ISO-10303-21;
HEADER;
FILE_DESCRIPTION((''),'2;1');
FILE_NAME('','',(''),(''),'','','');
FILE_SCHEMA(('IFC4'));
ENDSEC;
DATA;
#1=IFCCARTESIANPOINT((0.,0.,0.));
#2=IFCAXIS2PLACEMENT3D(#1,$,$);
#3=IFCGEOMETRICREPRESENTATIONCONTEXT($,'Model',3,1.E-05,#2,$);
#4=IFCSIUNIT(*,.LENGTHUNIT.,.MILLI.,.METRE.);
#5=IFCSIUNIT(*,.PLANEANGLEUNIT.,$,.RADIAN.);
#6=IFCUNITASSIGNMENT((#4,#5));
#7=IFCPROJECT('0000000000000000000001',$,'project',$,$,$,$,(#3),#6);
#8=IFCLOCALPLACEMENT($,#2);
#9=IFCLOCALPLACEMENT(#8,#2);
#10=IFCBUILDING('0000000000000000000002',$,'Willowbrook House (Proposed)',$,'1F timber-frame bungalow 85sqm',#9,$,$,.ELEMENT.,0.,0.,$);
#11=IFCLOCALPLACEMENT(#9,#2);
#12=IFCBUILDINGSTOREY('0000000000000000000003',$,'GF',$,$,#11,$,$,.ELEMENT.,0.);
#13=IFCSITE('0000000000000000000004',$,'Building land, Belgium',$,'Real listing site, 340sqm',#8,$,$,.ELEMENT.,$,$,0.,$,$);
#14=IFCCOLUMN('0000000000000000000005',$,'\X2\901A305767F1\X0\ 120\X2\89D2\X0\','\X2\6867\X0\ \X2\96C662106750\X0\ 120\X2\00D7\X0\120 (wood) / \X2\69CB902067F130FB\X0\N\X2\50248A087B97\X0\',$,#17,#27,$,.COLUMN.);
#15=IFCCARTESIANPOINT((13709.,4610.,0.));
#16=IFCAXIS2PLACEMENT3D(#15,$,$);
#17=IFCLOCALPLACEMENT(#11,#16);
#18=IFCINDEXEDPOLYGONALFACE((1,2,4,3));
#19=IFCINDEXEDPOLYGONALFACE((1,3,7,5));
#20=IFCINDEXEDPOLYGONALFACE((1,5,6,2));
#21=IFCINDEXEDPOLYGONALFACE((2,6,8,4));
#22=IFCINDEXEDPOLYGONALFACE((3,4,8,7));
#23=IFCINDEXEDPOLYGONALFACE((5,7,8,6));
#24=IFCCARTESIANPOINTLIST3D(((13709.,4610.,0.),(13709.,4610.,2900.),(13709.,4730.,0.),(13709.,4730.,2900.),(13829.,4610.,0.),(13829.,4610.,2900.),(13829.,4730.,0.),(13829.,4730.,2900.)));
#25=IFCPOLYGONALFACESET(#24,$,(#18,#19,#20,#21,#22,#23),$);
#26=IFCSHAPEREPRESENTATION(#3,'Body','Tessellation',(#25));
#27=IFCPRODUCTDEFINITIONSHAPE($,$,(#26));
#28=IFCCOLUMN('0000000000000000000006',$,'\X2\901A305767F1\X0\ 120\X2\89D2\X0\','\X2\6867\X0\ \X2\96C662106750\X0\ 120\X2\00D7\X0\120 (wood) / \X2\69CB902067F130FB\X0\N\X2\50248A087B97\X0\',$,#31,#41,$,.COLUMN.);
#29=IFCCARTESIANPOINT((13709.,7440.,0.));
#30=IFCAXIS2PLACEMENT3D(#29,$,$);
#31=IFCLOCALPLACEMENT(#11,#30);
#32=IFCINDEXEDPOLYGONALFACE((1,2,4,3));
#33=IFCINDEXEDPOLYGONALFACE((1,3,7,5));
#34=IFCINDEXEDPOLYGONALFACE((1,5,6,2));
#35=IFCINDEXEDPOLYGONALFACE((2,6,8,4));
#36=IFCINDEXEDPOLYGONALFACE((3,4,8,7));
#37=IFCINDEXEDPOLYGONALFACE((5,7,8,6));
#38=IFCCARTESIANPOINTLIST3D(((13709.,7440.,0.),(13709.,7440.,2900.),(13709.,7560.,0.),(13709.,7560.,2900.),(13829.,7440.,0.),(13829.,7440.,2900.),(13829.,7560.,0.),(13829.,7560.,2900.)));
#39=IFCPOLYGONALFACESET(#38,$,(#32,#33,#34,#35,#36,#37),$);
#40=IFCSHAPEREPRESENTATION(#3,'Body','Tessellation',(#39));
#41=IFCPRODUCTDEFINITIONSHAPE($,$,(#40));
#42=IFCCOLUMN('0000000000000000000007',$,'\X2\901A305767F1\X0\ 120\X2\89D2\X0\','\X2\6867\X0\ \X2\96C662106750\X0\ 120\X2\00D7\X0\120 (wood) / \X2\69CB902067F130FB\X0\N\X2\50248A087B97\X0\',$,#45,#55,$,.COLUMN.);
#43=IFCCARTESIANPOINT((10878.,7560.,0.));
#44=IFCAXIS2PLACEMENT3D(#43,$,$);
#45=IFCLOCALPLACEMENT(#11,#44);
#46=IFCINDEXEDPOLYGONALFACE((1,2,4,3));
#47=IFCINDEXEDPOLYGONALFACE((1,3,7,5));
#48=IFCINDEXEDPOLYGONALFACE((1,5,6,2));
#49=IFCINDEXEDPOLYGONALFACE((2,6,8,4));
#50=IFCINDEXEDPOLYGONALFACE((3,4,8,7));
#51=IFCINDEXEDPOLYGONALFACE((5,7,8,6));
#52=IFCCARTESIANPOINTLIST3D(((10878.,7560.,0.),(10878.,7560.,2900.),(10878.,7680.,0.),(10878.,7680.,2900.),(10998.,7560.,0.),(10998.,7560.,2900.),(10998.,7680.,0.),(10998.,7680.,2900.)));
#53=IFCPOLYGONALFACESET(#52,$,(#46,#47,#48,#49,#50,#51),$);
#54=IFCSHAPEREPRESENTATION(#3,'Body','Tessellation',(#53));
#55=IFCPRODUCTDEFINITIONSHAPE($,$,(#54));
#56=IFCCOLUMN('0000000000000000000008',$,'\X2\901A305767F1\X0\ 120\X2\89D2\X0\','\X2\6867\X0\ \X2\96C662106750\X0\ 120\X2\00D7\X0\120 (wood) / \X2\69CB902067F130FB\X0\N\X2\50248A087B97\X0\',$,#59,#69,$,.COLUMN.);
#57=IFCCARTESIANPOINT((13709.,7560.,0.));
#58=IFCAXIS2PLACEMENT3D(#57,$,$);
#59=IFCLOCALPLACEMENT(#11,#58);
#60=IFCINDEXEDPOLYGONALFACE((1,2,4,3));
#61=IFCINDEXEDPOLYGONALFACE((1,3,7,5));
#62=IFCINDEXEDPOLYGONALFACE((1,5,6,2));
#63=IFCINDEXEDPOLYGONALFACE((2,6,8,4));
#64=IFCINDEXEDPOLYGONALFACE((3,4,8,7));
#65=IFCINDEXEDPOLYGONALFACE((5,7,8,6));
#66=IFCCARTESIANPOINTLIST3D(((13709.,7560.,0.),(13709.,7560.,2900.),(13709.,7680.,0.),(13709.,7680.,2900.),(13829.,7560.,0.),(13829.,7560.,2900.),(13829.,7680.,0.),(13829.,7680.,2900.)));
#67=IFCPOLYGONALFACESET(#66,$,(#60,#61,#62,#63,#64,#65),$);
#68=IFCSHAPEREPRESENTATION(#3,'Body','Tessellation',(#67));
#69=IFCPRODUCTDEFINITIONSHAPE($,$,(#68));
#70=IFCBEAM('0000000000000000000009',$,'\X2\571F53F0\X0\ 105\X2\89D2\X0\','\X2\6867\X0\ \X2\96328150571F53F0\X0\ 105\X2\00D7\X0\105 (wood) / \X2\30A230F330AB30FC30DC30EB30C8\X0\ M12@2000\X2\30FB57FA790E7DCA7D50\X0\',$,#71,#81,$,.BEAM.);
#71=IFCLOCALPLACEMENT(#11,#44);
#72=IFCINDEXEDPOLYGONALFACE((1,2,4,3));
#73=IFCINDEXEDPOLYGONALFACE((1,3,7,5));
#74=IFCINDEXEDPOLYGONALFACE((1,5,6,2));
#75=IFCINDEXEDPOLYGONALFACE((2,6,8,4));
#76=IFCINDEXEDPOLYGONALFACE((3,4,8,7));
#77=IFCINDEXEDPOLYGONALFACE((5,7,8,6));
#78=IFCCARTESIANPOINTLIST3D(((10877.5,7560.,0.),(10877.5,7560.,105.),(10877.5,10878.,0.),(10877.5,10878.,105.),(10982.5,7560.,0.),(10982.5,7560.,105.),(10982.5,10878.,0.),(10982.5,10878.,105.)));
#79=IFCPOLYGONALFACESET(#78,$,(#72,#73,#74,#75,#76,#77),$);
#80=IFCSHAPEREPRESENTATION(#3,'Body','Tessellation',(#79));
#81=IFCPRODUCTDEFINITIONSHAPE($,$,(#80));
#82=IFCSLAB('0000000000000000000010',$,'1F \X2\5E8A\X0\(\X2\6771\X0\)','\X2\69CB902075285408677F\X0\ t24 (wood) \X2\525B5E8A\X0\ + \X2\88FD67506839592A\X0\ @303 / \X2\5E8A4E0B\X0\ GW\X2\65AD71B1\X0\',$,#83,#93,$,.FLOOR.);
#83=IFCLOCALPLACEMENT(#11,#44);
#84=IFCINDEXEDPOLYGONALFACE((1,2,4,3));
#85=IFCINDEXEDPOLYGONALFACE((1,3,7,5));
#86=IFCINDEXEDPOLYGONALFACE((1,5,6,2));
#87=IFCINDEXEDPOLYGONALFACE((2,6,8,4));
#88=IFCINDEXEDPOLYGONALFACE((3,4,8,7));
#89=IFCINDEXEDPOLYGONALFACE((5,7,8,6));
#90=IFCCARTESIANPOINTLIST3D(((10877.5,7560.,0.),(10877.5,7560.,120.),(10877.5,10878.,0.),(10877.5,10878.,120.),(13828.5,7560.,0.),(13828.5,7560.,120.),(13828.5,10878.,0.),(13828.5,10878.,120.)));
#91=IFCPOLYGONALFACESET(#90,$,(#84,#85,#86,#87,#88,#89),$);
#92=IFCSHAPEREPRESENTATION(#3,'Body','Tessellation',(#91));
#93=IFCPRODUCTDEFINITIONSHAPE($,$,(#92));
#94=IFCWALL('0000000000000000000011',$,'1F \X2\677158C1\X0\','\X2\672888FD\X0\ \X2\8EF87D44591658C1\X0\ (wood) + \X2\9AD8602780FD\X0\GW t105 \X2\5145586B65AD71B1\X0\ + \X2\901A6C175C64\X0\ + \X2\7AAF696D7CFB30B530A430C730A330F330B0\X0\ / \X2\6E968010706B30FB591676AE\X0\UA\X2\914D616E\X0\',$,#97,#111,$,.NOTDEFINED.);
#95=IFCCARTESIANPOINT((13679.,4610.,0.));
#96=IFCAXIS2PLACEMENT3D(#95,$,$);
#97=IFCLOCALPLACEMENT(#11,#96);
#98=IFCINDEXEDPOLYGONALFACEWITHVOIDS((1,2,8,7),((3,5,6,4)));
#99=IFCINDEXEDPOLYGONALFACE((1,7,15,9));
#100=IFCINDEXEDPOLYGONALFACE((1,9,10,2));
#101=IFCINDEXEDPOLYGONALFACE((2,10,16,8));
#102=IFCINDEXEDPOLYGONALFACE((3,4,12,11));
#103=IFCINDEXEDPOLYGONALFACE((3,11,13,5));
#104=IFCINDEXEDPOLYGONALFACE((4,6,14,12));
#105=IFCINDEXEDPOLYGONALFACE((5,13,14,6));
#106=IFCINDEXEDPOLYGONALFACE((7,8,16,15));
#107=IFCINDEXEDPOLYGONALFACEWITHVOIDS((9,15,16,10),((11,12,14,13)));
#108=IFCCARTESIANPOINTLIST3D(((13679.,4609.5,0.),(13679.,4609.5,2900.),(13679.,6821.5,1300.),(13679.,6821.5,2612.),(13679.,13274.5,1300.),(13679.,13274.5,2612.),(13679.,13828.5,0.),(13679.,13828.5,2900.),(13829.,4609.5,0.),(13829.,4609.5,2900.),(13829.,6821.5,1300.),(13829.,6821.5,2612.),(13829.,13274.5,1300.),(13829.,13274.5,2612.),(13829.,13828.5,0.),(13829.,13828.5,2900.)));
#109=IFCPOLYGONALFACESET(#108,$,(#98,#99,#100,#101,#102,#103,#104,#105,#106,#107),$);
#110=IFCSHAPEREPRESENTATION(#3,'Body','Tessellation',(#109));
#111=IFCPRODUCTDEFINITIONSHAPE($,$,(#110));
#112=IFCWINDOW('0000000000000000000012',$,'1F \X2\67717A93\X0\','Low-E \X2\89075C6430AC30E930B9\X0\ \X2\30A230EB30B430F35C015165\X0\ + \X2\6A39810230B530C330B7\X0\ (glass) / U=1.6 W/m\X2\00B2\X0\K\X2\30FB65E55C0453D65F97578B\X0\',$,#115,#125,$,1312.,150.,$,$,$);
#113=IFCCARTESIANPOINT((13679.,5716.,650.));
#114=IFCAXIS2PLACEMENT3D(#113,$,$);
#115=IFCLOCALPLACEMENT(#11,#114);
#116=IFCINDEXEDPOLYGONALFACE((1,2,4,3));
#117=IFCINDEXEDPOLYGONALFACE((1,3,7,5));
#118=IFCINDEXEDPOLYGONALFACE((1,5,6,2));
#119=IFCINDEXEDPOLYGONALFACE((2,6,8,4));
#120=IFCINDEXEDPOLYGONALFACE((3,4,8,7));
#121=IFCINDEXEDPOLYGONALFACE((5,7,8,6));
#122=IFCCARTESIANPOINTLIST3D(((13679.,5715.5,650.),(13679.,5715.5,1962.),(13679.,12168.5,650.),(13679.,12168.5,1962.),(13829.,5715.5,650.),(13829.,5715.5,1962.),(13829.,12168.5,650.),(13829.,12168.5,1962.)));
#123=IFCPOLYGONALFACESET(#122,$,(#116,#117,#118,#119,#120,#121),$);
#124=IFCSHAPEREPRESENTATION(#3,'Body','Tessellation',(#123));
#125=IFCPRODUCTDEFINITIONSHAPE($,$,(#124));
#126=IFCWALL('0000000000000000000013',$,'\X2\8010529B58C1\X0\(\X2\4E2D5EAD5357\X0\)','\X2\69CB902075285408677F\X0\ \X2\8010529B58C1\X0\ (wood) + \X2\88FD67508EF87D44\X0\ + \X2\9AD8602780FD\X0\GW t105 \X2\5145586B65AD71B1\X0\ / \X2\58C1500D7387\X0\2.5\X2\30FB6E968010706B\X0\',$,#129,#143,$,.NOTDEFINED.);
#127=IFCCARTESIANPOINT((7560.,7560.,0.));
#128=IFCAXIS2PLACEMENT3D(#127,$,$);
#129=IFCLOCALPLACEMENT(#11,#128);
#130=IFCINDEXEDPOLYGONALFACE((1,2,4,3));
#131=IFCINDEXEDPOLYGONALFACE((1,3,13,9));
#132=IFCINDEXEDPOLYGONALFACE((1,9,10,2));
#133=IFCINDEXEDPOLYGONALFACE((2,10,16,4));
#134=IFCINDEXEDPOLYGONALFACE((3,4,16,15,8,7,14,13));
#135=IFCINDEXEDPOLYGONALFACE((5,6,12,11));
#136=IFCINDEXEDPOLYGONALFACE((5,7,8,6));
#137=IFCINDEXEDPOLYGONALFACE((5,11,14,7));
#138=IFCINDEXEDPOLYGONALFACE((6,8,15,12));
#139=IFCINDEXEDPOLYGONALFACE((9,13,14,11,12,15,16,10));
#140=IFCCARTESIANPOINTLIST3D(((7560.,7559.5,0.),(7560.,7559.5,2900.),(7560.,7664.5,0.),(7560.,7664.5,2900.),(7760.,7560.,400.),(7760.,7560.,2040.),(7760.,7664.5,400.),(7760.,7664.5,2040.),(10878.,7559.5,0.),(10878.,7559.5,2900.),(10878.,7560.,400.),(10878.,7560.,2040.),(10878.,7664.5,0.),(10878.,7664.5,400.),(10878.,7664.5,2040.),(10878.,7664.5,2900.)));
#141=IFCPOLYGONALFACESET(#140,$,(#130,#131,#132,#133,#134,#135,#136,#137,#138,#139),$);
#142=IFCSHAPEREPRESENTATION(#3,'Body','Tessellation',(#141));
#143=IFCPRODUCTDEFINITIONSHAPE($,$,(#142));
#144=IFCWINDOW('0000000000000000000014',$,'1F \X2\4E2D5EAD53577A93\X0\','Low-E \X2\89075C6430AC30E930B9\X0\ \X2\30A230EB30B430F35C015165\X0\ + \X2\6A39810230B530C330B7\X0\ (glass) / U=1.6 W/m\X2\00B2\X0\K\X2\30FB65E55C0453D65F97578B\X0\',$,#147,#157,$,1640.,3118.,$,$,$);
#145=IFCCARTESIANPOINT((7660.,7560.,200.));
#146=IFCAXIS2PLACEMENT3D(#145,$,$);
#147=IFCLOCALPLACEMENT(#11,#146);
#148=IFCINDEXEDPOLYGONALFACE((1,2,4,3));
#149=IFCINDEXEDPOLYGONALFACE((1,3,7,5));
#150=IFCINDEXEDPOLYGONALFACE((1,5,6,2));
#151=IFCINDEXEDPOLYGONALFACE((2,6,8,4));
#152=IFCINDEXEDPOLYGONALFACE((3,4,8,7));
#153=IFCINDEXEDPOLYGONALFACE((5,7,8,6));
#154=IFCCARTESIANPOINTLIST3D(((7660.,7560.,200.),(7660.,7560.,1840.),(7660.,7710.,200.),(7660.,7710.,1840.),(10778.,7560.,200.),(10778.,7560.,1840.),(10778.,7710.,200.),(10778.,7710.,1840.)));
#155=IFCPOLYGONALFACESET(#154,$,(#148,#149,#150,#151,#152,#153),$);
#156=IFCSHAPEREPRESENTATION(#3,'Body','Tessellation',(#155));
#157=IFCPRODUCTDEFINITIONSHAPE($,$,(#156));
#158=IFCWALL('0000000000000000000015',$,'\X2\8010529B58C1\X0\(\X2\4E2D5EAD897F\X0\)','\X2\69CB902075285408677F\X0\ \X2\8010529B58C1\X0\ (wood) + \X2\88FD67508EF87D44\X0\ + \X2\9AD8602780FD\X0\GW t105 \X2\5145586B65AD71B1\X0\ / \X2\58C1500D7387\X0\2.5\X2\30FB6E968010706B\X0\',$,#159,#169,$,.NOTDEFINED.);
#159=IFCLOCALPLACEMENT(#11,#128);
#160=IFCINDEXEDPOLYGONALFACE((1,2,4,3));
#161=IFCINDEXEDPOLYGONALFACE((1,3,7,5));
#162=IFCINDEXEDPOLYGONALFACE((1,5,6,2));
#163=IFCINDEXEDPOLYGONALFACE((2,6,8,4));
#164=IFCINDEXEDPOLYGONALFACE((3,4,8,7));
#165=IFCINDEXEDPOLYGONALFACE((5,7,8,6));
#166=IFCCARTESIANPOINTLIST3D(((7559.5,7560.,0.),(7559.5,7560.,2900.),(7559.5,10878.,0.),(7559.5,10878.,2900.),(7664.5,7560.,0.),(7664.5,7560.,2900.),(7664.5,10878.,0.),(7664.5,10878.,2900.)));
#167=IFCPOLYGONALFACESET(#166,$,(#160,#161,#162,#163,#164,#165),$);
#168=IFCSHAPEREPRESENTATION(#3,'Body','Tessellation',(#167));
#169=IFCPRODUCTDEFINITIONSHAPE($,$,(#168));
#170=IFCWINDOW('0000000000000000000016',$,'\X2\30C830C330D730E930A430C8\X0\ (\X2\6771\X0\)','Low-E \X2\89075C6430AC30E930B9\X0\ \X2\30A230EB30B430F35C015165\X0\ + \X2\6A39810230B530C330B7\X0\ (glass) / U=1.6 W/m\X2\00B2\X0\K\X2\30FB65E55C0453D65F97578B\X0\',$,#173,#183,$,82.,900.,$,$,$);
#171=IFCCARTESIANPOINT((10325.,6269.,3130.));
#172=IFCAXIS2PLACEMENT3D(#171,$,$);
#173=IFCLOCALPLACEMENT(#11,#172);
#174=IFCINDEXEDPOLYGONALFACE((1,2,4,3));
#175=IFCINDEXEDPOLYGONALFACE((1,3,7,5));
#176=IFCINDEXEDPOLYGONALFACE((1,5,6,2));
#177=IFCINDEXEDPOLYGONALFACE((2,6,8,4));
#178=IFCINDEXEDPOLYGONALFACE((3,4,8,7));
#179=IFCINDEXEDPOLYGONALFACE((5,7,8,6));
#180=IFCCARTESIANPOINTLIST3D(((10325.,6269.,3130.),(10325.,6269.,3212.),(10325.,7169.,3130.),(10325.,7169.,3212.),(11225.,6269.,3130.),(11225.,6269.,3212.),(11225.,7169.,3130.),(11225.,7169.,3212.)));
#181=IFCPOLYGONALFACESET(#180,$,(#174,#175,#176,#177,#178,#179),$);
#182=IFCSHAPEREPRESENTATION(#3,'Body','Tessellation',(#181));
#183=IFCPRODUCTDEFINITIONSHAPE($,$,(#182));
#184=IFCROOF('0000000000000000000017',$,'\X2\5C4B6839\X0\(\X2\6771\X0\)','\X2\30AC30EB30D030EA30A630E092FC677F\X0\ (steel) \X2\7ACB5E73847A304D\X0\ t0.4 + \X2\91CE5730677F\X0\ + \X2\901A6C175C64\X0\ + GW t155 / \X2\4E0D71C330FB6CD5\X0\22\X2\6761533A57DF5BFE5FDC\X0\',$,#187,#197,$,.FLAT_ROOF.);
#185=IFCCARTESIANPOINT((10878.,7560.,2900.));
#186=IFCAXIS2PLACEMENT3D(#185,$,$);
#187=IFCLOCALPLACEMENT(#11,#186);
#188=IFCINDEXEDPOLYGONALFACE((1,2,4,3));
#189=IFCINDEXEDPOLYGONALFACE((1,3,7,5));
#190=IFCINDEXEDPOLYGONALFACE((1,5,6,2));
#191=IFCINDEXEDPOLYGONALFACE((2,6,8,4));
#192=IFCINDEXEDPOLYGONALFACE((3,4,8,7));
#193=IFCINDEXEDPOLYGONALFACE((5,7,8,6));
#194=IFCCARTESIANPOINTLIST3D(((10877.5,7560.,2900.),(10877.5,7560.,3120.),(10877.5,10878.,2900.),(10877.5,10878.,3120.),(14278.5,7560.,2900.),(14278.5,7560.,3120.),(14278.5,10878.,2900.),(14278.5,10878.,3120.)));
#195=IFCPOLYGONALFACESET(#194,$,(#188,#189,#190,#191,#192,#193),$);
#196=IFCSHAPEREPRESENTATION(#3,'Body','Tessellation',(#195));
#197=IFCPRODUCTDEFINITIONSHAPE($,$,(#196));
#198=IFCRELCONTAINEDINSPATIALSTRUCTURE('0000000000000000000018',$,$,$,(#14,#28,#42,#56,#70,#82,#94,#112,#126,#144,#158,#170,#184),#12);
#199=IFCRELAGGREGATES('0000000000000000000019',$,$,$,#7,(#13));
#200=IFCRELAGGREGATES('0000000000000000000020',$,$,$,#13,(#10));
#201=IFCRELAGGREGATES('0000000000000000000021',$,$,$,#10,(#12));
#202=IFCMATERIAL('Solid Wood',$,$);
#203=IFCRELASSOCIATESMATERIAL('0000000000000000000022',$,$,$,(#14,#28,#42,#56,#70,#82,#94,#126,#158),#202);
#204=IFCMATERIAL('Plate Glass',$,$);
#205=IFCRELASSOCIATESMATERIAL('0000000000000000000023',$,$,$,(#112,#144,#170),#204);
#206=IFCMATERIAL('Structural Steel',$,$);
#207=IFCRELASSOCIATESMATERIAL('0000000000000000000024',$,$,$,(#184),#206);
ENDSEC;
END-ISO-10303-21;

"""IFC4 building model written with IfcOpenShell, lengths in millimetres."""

from ifc_helpers import new_model, si_unit, frame, frame_2d, origin, place, context, project, spatial, rectangle, extrude, material, element, fill, save


model = new_model("IFC4")

# Units and contexts
model_context = context("Model", 3, precision=1e-05, world=origin())
ifc_project = project(units=[si_unit("LENGTHUNIT", "METRE", prefix="MILLI"), si_unit("PLANEANGLEUNIT", "RADIAN")], contexts=[model_context])

# Site, building, storey
site_placement = place(None, origin())
site = spatial("IfcSite", under=ifc_project, at=site_placement, Name="Building land, Belgium", ObjectType="Real listing site, 340sqm", CompositionType="ELEMENT", RefElevation=0.0)
building_placement = place(site_placement, origin())
building = spatial("IfcBuilding", under=site, at=building_placement, Name="Willowbrook House (Proposed)", ObjectType="1F timber-frame bungalow 85sqm", CompositionType="ELEMENT", ElevationOfRefHeight=0.0, ElevationOfTerrain=0.0)
storey_placement = place(building_placement, origin())
storey = spatial("IfcBuildingStorey", under=building, at=storey_placement, Name="GF", CompositionType="ELEMENT", Elevation=0.0)

# Columns
ifc_material_1 = material(Name="Solid Wood")
column_1_placement = place(storey_placement, frame((13709.0, 4610.0, 0.0)))
element("IfcColumn", 1, at=column_1_placement, inside=storey, material=ifc_material_1, Name="通し柱 120角", Description="桧 集成材 120×120 (wood) / 構造柱・N値計算", PredefinedType="COLUMN", context=model_context, shape_type="SweptSolid", body=[
    extrude(rectangle(XDim=120.0, YDim=120.0, at=frame_2d((60.0, 60.0))), frame((13709.0, 4610.0, 0.0)), (0.0, 0.0, 1.0), 2900.0),
])
column_2_placement = place(storey_placement, frame((13709.0, 7440.0, 0.0)))
element("IfcColumn", 2, at=column_2_placement, inside=storey, material=ifc_material_1, Name="通し柱 120角", Description="桧 集成材 120×120 (wood) / 構造柱・N値計算", PredefinedType="COLUMN", context=model_context, shape_type="SweptSolid", body=[
    extrude(rectangle(XDim=120.0, YDim=120.0, at=frame_2d((60.0, 60.0))), frame((13709.0, 7440.0, 0.0)), (0.0, 0.0, 1.0), 2900.0),
])
column_3_placement = place(storey_placement, frame((10878.0, 7560.0, 0.0)))
element("IfcColumn", 3, at=column_3_placement, inside=storey, material=ifc_material_1, Name="通し柱 120角", Description="桧 集成材 120×120 (wood) / 構造柱・N値計算", PredefinedType="COLUMN", context=model_context, shape_type="SweptSolid", body=[
    extrude(rectangle(XDim=120.0, YDim=120.0, at=frame_2d((60.0, 60.0))), frame((10878.0, 7560.0, 0.0)), (0.0, 0.0, 1.0), 2900.0),
])
column_4_placement = place(storey_placement, frame((13709.0, 7560.0, 0.0)))
element("IfcColumn", 4, at=column_4_placement, inside=storey, material=ifc_material_1, Name="通し柱 120角", Description="桧 集成材 120×120 (wood) / 構造柱・N値計算", PredefinedType="COLUMN", context=model_context, shape_type="SweptSolid", body=[
    extrude(rectangle(XDim=120.0, YDim=120.0, at=frame_2d((60.0, 60.0))), frame((13709.0, 7560.0, 0.0)), (0.0, 0.0, 1.0), 2900.0),
])

# Beam
beam_1_placement = place(storey_placement, frame((10878.0, 7560.0, 0.0)))
element("IfcBeam", 5, at=beam_1_placement, inside=storey, material=ifc_material_1, Name="土台 105角", Description="桧 防腐土台 105×105 (wood) / アンカーボルト M12@2000・基礎緊結", PredefinedType="BEAM", context=model_context, shape_type="SweptSolid", body=[
    extrude(rectangle(XDim=105.0, YDim=3318.0, at=frame_2d((52.0, 1659.0))), frame((10878.0, 7560.0, 0.0)), (0.0, 0.0, 1.0), 105.0),
])

# Slab
slab_placement = place(storey_placement, frame((10878.0, 7560.0, 0.0)))
element("IfcSlab", 6, at=slab_placement, inside=storey, material=ifc_material_1, Name="1F 床(東)", Description="構造用合板 t24 (wood) 剛床 + 製材根太 @303 / 床下 GW断熱", PredefinedType="FLOOR", context=model_context, shape_type="SweptSolid", body=[
    extrude(rectangle(XDim=2951.0, YDim=3318.0, at=frame_2d((1475.0, 1659.0))), frame((10878.0, 7560.0, 0.0)), (0.0, 0.0, 1.0), 120.0),
])

# Walls, openings, windows
wall_1_placement = place(storey_placement, frame((13679.0, 4610.0, 0.0)))
wall_1 = element("IfcWall", 7, at=wall_1_placement, inside=storey, material=ifc_material_1, Name="1F 東壁", Description="木製 軸組外壁 (wood) + 高性能GW t105 充填断熱 + 通気層 + 窯業系サイディング / 準耐火・外皮UA配慮", PredefinedType="NOTDEFINED", context=model_context, shape_type="SweptSolid", body=[
    extrude(rectangle(XDim=150.0, YDim=9219.0, at=frame_2d((75.0, 4609.0))), frame((13679.0, 4610.0, 0.0)), (0.0, 0.0, 1.0), 2900.0),
])
opening_1_placement = place(storey_placement, frame((13679.0, 5716.0, 650.0)))
opening_1 = element("IfcOpeningElement", 8, at=opening_1_placement, cuts=wall_1, PredefinedType="NOTDEFINED", context=model_context, shape_type="SweptSolid", body=[
    extrude(rectangle(XDim=150.0, YDim=6453.0, at=frame_2d((75.0, 3226.0))), frame((13679.0, 5716.0, 650.0)), (0.0, 0.0, 1.0), 1312.0),
])
ifc_material_2 = material(Name="Plate Glass")
window_1_placement = place(storey_placement, frame((13679.0, 5716.0, 650.0)))
window_1 = element("IfcWindow", 9, at=window_1_placement, inside=storey, material=ifc_material_2, Name="1F 東窓", Description="Low-E 複層ガラス アルゴン封入 + 樹脂サッシ (glass) / U=1.6 W/m²K・日射取得型", OverallHeight=1312.0, OverallWidth=150.0, context=model_context, shape_type="SweptSolid", body=[
    extrude(rectangle(XDim=150.0, YDim=6453.0, at=frame_2d((75.0, 3226.0))), frame((13679.0, 5716.0, 650.0)), (0.0, 0.0, 1.0), 1312.0),
])
fill(opening_1, window_1)
wall_2_placement = place(storey_placement, frame((7560.0, 7560.0, 0.0)))
wall_2 = element("IfcWall", 10, at=wall_2_placement, inside=storey, material=ifc_material_1, Name="耐力壁(中庭南)", Description="構造用合板 耐力壁 (wood) + 製材軸組 + 高性能GW t105 充填断熱 / 壁倍率2.5・準耐火", PredefinedType="NOTDEFINED", context=model_context, shape_type="SweptSolid", body=[
    extrude(rectangle(XDim=3318.0, YDim=105.0, at=frame_2d((1659.0, 52.0))), frame((7560.0, 7560.0, 0.0)), (0.0, 0.0, 1.0), 2900.0),
])
opening_2_placement = place(storey_placement, frame((7660.0, 7560.0, 200.0)))
opening_2 = element("IfcOpeningElement", 11, at=opening_2_placement, cuts=wall_2, PredefinedType="NOTDEFINED", context=model_context, shape_type="SweptSolid", body=[
    extrude(rectangle(XDim=3118.0, YDim=150.0, at=frame_2d((1559.0, 75.0))), frame((7660.0, 7560.0, 200.0)), (0.0, 0.0, 1.0), 1640.0),
])
window_2_placement = place(storey_placement, frame((7660.0, 7560.0, 200.0)))
window_2 = element("IfcWindow", 12, at=window_2_placement, inside=storey, material=ifc_material_2, Name="1F 中庭南窓", Description="Low-E 複層ガラス アルゴン封入 + 樹脂サッシ (glass) / U=1.6 W/m²K・日射取得型", OverallHeight=1640.0, OverallWidth=3118.0, context=model_context, shape_type="SweptSolid", body=[
    extrude(rectangle(XDim=3118.0, YDim=150.0, at=frame_2d((1559.0, 75.0))), frame((7660.0, 7560.0, 200.0)), (0.0, 0.0, 1.0), 1640.0),
])
fill(opening_2, window_2)

# Wall
wall_3_placement = place(storey_placement, frame((7560.0, 7560.0, 0.0)))
element("IfcWall", 13, at=wall_3_placement, inside=storey, material=ifc_material_1, Name="耐力壁(中庭西)", Description="構造用合板 耐力壁 (wood) + 製材軸組 + 高性能GW t105 充填断熱 / 壁倍率2.5・準耐火", PredefinedType="NOTDEFINED", context=model_context, shape_type="SweptSolid", body=[
    extrude(rectangle(XDim=105.0, YDim=3318.0, at=frame_2d((52.0, 1659.0))), frame((7560.0, 7560.0, 0.0)), (0.0, 0.0, 1.0), 2900.0),
])

# Window
window_3_placement = place(storey_placement, frame((10325.0, 6269.0, 3130.0)))
element("IfcWindow", 14, at=window_3_placement, inside=storey, material=ifc_material_2, Name="トップライト (東)", Description="Low-E 複層ガラス アルゴン封入 + 樹脂サッシ (glass) / U=1.6 W/m²K・日射取得型", OverallHeight=82.0, OverallWidth=900.0, context=model_context, shape_type="SweptSolid", body=[
    extrude(rectangle(XDim=900.0, YDim=900.0, at=frame_2d((450.0, 450.0))), frame((10325.0, 6269.0, 3130.0)), (0.0, 0.0, 1.0), 82.0),
])

# Roof
ifc_material_3 = material(Name="Structural Steel")
roof_placement = place(storey_placement, frame((10878.0, 7560.0, 2900.0)))
element("IfcRoof", 15, at=roof_placement, inside=storey, material=ifc_material_3, Name="屋根(東)", Description="ガルバリウム鋼板 (steel) 立平葺き t0.4 + 野地板 + 通気層 + GW t155 / 不燃・法22条区域対応", PredefinedType="FLAT_ROOF", context=model_context, shape_type="SweptSolid", body=[
    extrude(rectangle(XDim=3401.0, YDim=3318.0, at=frame_2d((1700.0, 1659.0))), frame((10878.0, 7560.0, 2900.0)), (0.0, 0.0, 1.0), 220.0),
])

save(model, "model.ifc")
